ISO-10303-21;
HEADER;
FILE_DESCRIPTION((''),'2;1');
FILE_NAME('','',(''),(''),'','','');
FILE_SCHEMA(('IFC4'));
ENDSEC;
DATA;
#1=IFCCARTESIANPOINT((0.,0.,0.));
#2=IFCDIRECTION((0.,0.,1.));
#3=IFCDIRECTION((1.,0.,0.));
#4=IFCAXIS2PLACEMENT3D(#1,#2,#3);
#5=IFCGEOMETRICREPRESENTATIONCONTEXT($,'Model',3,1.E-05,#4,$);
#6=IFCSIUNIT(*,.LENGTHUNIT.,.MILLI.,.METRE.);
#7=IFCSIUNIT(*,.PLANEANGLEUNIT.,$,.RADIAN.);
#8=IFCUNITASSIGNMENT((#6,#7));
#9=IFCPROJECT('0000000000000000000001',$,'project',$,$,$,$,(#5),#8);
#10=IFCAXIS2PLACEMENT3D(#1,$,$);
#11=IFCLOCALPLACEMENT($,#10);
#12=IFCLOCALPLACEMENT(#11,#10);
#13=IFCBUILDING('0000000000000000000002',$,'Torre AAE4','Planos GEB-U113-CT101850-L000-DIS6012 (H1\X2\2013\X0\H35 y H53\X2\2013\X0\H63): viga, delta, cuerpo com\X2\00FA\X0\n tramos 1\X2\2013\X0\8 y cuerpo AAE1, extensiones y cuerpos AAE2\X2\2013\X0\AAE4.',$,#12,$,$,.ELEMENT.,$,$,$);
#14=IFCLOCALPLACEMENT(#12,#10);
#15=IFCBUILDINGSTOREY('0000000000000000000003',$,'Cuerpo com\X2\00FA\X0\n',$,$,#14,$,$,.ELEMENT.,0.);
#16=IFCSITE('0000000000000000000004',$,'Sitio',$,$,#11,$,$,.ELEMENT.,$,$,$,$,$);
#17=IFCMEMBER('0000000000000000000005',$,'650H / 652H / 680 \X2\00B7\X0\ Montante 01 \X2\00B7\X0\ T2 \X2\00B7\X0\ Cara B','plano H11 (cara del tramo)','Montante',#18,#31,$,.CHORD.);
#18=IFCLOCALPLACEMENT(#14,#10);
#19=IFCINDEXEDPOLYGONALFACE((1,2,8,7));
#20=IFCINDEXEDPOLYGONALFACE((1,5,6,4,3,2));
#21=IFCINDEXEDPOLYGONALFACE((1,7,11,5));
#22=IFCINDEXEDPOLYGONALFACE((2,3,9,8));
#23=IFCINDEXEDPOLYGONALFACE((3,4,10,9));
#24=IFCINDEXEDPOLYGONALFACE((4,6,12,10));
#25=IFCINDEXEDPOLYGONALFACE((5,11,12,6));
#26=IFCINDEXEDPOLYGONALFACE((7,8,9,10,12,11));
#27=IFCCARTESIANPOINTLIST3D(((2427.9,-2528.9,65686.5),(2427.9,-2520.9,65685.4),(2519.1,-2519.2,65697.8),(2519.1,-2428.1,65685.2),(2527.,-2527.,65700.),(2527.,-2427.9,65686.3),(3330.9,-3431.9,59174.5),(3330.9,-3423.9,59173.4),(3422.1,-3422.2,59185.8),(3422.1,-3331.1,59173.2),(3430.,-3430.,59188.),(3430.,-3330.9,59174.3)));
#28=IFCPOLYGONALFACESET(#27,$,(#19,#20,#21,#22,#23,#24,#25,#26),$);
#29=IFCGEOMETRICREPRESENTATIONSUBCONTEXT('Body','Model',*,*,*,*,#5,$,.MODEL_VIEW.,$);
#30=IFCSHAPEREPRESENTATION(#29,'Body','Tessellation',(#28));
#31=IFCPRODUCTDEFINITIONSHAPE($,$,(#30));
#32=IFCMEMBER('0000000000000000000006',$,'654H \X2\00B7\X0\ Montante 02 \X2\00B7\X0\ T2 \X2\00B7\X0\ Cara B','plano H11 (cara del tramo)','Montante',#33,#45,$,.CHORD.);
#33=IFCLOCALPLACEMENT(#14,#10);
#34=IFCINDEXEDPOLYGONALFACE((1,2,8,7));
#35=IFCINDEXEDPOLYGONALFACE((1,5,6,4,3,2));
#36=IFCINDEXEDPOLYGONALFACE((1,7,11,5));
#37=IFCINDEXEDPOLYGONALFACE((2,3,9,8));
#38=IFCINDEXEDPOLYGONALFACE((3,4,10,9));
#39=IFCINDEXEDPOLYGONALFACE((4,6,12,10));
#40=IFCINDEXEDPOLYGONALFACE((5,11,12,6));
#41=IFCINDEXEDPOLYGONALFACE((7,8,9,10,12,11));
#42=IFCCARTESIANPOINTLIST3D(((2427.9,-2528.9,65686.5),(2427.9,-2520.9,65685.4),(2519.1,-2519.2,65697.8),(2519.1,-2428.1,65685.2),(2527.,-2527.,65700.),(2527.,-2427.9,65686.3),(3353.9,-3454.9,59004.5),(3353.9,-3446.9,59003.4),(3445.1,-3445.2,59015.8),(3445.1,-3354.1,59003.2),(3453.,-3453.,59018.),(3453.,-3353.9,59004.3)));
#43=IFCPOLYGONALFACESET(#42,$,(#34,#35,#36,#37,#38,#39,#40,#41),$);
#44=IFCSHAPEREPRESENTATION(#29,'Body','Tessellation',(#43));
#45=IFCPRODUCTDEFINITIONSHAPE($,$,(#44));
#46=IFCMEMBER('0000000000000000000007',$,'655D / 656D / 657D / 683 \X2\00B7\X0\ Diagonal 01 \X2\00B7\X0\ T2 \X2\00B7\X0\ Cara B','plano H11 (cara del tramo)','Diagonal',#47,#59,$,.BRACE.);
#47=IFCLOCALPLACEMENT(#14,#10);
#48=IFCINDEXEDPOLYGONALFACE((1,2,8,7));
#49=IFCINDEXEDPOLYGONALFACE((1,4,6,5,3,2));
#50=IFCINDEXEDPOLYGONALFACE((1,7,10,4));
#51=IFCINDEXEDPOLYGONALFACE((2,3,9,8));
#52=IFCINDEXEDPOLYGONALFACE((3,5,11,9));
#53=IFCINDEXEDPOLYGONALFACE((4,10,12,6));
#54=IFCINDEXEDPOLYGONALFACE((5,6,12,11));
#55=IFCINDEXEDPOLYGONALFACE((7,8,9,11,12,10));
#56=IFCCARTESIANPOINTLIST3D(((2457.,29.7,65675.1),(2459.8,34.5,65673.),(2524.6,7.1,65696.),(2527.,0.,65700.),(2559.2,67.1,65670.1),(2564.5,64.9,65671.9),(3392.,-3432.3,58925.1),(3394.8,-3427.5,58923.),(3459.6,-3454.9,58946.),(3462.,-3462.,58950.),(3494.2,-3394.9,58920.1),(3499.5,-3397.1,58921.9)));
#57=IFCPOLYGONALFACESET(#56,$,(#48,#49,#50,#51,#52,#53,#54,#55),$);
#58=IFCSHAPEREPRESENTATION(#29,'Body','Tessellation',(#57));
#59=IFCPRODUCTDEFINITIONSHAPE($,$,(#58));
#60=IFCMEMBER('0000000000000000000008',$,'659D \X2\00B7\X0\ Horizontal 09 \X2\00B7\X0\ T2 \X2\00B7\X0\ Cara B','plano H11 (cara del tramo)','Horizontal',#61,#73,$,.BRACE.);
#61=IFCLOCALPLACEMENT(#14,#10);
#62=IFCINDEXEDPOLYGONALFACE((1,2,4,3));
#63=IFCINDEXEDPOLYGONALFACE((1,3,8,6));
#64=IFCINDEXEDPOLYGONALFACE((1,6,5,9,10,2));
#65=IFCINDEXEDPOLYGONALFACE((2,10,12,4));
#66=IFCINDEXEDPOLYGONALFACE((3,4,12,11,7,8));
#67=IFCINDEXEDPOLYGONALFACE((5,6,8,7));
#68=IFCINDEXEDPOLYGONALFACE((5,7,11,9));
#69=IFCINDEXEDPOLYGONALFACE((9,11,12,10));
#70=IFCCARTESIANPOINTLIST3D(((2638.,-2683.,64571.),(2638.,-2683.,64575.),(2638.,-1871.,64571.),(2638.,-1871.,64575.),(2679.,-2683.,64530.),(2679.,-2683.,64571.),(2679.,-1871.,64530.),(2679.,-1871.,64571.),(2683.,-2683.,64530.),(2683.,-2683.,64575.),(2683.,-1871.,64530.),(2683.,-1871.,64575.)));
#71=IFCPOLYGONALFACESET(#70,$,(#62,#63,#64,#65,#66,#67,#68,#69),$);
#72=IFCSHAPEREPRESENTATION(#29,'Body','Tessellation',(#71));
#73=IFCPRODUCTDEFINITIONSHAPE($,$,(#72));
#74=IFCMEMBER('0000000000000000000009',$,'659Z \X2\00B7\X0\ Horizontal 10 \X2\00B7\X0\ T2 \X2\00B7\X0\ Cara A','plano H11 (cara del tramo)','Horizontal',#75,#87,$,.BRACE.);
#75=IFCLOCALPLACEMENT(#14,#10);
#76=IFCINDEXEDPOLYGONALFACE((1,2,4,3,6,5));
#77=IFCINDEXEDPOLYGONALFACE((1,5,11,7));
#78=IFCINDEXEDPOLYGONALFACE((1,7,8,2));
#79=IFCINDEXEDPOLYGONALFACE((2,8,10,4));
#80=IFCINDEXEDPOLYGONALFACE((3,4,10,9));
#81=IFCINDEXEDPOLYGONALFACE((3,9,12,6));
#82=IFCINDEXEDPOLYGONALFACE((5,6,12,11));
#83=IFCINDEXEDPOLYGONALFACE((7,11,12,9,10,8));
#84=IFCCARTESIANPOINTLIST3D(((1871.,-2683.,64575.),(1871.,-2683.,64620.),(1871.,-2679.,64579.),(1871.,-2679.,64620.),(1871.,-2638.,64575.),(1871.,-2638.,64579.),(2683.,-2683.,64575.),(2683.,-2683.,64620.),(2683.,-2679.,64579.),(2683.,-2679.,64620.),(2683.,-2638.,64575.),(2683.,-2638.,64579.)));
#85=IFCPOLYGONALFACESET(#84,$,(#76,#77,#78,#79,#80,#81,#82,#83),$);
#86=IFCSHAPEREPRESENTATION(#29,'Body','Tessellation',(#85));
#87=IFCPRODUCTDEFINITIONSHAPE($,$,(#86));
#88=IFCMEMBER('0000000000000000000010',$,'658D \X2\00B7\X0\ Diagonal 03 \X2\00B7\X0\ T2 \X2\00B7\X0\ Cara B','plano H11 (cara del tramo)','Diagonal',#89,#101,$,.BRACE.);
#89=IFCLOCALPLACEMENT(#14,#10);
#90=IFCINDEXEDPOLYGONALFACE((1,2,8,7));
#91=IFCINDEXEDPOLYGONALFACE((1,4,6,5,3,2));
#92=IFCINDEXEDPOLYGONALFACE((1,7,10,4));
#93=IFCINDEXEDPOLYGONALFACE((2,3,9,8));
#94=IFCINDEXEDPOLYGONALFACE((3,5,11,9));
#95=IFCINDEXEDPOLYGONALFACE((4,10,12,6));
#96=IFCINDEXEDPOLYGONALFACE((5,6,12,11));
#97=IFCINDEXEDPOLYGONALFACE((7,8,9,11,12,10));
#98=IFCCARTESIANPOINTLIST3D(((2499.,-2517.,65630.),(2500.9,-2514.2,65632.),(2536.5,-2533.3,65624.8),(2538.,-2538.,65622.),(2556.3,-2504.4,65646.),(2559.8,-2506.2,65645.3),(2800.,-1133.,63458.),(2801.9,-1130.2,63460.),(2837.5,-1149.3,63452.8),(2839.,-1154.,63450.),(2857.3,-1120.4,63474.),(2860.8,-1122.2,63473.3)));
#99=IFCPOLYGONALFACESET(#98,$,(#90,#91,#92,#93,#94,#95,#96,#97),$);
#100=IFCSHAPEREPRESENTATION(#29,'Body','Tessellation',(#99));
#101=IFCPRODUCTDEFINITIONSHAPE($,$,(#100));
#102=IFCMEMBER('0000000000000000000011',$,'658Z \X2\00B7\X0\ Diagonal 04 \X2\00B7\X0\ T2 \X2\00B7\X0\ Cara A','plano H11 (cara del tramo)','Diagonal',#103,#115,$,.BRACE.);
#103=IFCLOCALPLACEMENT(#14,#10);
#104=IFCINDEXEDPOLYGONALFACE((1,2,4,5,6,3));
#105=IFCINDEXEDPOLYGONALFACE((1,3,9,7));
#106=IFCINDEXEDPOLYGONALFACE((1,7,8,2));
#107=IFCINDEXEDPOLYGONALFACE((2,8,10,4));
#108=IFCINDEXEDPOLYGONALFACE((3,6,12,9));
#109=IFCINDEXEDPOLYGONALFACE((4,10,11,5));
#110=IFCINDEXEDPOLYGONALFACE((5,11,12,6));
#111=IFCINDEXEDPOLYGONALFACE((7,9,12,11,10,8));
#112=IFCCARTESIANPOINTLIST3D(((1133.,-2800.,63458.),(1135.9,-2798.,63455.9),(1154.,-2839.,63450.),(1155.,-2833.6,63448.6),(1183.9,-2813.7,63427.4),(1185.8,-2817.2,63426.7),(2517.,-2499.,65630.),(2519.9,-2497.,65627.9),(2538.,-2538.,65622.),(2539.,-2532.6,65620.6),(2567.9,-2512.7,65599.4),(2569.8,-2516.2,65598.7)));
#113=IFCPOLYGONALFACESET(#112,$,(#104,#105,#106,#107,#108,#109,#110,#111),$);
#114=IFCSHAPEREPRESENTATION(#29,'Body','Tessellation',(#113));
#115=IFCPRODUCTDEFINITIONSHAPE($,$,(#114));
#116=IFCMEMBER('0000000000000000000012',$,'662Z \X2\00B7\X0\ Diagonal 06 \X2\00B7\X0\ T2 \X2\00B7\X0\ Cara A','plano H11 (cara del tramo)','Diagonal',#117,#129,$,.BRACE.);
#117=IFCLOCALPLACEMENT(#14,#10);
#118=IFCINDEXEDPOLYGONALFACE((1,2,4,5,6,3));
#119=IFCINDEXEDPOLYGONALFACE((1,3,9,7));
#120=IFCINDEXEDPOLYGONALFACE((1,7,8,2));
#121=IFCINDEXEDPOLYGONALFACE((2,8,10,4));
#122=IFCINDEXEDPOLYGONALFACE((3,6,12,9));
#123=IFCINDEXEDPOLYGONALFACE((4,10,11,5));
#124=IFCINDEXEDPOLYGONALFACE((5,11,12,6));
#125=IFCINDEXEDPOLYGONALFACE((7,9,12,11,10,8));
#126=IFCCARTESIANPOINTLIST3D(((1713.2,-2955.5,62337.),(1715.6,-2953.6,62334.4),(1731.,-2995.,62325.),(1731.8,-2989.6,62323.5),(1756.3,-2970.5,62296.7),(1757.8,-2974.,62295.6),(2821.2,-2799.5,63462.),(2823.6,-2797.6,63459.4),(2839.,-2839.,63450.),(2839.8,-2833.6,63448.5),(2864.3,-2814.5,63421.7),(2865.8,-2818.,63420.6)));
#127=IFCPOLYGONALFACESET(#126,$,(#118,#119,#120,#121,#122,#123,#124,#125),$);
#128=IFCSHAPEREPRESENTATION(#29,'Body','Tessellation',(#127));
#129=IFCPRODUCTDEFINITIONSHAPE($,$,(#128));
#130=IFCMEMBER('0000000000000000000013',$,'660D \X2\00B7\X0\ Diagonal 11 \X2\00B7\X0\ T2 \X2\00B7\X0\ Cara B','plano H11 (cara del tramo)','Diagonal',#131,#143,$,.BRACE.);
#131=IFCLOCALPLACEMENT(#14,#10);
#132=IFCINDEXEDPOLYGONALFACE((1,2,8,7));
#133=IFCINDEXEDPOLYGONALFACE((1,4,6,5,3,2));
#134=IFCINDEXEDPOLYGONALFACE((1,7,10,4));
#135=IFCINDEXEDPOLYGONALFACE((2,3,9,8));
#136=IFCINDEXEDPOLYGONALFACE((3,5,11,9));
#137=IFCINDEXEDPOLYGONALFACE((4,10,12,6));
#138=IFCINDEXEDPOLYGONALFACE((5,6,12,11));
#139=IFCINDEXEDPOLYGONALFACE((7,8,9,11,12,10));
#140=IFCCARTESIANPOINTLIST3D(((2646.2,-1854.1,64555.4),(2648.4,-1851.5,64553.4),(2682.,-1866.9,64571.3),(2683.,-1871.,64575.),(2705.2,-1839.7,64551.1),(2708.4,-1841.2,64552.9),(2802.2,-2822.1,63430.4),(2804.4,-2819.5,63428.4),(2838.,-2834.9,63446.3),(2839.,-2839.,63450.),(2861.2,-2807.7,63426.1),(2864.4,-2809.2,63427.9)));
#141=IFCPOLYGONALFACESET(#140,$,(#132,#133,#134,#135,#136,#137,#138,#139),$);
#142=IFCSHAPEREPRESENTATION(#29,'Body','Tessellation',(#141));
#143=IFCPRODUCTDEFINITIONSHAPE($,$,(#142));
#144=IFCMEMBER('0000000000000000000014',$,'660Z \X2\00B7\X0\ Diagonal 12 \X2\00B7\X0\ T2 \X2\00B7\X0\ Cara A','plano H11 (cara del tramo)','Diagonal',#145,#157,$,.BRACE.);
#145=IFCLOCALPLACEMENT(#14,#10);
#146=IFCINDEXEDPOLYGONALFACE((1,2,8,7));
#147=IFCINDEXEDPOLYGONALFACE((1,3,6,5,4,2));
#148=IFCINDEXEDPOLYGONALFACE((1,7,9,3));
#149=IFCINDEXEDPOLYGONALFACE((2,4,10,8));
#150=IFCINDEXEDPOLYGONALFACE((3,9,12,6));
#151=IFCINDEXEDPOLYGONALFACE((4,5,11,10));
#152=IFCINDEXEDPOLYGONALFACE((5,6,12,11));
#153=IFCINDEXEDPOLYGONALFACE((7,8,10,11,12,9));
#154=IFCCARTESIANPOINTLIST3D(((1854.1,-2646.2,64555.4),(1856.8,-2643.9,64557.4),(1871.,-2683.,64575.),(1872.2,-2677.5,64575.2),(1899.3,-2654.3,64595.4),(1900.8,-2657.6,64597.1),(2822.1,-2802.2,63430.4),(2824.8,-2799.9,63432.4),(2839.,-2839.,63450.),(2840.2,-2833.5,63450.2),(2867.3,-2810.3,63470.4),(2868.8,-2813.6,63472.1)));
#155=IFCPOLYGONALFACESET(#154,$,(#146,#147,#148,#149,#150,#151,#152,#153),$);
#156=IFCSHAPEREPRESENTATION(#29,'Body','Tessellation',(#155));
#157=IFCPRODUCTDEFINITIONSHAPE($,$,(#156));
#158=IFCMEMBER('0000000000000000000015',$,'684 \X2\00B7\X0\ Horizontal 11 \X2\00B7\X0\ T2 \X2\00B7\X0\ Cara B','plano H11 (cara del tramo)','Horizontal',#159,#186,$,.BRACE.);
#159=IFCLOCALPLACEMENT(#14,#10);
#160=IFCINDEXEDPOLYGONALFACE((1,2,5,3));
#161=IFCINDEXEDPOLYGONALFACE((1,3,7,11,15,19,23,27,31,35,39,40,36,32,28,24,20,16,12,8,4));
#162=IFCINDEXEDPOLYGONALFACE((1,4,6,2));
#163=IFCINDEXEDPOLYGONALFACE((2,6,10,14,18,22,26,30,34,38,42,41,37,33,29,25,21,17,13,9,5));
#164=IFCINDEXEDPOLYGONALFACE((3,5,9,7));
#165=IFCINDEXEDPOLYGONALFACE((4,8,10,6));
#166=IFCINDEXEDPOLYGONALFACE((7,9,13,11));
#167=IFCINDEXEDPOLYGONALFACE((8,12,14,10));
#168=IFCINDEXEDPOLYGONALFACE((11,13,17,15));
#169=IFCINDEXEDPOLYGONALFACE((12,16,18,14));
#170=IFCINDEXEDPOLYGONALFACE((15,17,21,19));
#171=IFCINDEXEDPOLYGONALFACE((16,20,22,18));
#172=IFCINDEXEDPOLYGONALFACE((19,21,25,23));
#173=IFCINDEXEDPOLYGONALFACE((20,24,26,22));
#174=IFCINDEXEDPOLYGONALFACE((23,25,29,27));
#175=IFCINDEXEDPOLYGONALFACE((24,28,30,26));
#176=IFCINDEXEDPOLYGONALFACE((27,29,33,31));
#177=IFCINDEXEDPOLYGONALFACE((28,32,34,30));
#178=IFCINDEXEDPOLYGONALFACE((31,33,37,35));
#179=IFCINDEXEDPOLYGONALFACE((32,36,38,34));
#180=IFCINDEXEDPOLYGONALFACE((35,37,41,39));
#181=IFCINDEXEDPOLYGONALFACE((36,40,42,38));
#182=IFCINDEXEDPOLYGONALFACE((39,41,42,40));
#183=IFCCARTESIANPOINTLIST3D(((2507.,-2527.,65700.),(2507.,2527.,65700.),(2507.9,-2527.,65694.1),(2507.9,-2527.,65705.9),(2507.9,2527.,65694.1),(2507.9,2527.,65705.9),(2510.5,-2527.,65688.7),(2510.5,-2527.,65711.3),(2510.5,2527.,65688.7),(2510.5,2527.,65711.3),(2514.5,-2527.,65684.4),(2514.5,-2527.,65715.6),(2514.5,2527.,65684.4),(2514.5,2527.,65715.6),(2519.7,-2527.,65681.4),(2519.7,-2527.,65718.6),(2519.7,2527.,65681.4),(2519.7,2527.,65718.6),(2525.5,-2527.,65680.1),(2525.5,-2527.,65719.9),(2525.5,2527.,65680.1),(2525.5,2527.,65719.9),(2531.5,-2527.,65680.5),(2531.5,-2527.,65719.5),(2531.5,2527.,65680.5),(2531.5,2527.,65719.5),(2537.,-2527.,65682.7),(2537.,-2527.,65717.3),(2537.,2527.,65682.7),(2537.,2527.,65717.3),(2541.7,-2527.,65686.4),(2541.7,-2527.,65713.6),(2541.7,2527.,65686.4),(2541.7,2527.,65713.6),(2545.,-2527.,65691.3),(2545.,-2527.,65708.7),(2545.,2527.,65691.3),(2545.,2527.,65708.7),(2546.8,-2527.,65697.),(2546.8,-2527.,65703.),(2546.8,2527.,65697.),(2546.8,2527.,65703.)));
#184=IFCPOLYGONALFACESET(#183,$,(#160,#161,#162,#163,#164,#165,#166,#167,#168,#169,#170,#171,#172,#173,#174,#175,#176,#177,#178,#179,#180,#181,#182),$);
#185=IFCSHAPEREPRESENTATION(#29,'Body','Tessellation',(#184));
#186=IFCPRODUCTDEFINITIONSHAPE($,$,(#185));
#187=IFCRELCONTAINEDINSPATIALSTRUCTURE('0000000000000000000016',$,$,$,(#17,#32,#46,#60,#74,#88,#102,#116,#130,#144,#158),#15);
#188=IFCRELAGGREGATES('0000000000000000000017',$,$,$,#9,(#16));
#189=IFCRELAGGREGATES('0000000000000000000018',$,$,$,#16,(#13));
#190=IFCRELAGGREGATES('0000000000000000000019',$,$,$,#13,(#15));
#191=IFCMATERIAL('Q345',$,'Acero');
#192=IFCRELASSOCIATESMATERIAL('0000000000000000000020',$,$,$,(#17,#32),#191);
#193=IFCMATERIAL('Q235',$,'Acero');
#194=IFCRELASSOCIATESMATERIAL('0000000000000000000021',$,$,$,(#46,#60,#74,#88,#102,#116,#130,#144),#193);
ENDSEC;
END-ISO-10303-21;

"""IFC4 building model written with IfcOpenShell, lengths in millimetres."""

from ifc_helpers import new_model, si_unit, frame, frame_2d, origin, origin_with_axes, place, context, subcontext, project, spatial, circle, l_section, extrude, material, element, save


model = new_model("IFC4")

# Units and contexts
model_context = context("Model", 3, precision=1e-05, world=origin_with_axes())
body_context = subcontext(model_context, "Body", "Model", "MODEL_VIEW")
ifc_project = project(units=[si_unit("LENGTHUNIT", "METRE", prefix="MILLI"), si_unit("PLANEANGLEUNIT", "RADIAN")], contexts=[model_context])

# Site, building, storey
site_placement = place(None, origin())
site = spatial("IfcSite", under=ifc_project, at=site_placement, Name="Sitio", CompositionType="ELEMENT")
building_placement = place(site_placement, origin())
building = spatial("IfcBuilding", under=site, at=building_placement, Name="Torre AAE4", Description="Planos GEB-U113-CT101850-L000-DIS6012 (H1–H35 y H53–H63): viga, delta, cuerpo común tramos 1–8 y cuerpo AAE1, extensiones y cuerpos AAE2–AAE4.", CompositionType="ELEMENT")
storey_placement = place(building_placement, origin())
storey = spatial("IfcBuildingStorey", under=building, at=storey_placement, Name="Cuerpo común", CompositionType="ELEMENT", Elevation=0.0)

# Members
ifc_material_1 = material(Name="Q235", Category="Acero")
ifc_material_2 = material(Name="Q345", Category="Acero")
member_1_placement = place(storey_placement, frame((2527.0, -2527.0, 65700.0), z_axis=(0.136075, -0.136075, -0.981309), x_axis=(-0.990699, -0.01869, -0.134786)))
element("IfcMember", 1, at=member_1_placement, inside=storey, material=ifc_material_2, Name="650H / 652H / 680 · Montante 01 · T2 · Cara B", Description="plano H11 (cara del tramo)", ObjectType="Montante", PredefinedType="CHORD", context=body_context, shape_type="SweptSolid", body=[
    extrude(l_section(Depth=100.0, Width=100.0, Thickness=8.0, at=frame_2d((50.0, 50.0))), None, (0.0, 0.0, 1.0), 6636.0),
])
member_2_placement = place(storey_placement, frame((2527.0, -2527.0, 65700.0), z_axis=(0.135994, -0.135994, -0.981331), x_axis=(-0.99071, -0.018668, -0.134707)))
element("IfcMember", 2, at=member_2_placement, inside=storey, material=ifc_material_2, Name="654H · Montante 02 · T2 · Cara B", Description="plano H11 (cara del tramo)", ObjectType="Montante", PredefinedType="CHORD", context=body_context, shape_type="SweptSolid", body=[
    extrude(l_section(Depth=100.0, Width=100.0, Thickness=8.0, at=frame_2d((50.0, 50.0))), None, (0.0, 0.0, 1.0), 6809.1),
])
member_3_placement = place(storey_placement, frame((2527.0, 0.0, 65700.0), z_axis=(0.122327, -0.452937, -0.88311), x_axis=(-0.874879, 0.370937, -0.311437)))
element("IfcMember", 3, at=member_3_placement, inside=storey, material=ifc_material_1, Name="655D / 656D / 657D / 683 · Diagonal 01 · T2 · Cara B", Description="plano H11 (cara del tramo)", ObjectType="Diagonal", PredefinedType="BRACE", context=body_context, shape_type="SweptSolid", body=[
    extrude(l_section(Depth=80.0, Width=80.0, Thickness=6.0, at=frame_2d((40.0, 40.0))), None, (0.0, 0.0, 1.0), 7643.4),
])
for number, where, z_axis, x_axis, name in (
    (4, (2683.0, -1871.0, 64575.0), (0.0, -1.0, 0.0), (-1.0, 0.0, 0.0), "659D · Horizontal 09 · T2 · Cara B"),
    (5, (1871.0, -2683.0, 64575.0), (1.0, 0.0, 0.0), (0.0, 1.0, 0.0), "659Z · Horizontal 10 · T2 · Cara A"),
):
    element("IfcMember", number, at=place(storey_placement, frame(where, z_axis=z_axis, x_axis=x_axis)), inside=storey, material=ifc_material_1, Name=name, Description="plano H11 (cara del tramo)", ObjectType="Horizontal", PredefinedType="BRACE", context=body_context, shape_type="SweptSolid", body=[
        extrude(l_section(Depth=45.0, Width=45.0, Thickness=4.0, at=frame_2d((22.5, 22.5))), None, (0.0, 0.0, 1.0), 812.0),
    ])
for number, where, z_axis, x_axis, name in (
    (6, (2538.0, -2538.0, 65622.0), (0.116082, 0.533745, -0.83764), (-0.867013, 0.465896, 0.176717), "658D · Diagonal 03 · T2 · Cara B"),
    (7, (2538.0, -2538.0, 65622.0), (-0.533745, -0.116082, -0.83764), (-0.465896, 0.867013, 0.176717), "658Z · Diagonal 04 · T2 · Cara A"),
):
    element("IfcMember", number, at=place(storey_placement, frame(where, z_axis=z_axis, x_axis=x_axis)), inside=storey, material=ifc_material_1, Name=name, Description="plano H11 (cara del tramo)", ObjectType="Diagonal", PredefinedType="BRACE", context=body_context, shape_type="SweptSolid", body=[
        extrude(l_section(Depth=45.0, Width=45.0, Thickness=4.0, at=frame_2d((22.5, 22.5))), None, (0.0, 0.0, 1.0), 2593.0),
    ])
member_4_placement = place(storey_placement, frame((2839.0, -2839.0, 63450.0), z_axis=(-0.698304, -0.098317, -0.709018), x_axis=(-0.395503, 0.878588, 0.267696)))
element("IfcMember", 8, at=member_4_placement, inside=storey, material=ifc_material_1, Name="662Z · Diagonal 06 · T2 · Cara A", Description="plano H11 (cara del tramo)", ObjectType="Diagonal", PredefinedType="BRACE", context=body_context, shape_type="SweptSolid", body=[
    extrude(l_section(Depth=45.0, Width=45.0, Thickness=4.0, at=frame_2d((22.5, 22.5))), None, (0.0, 0.0, 1.0), 1586.7),
])
for number, where, z_axis, x_axis, name in (
    (9, (2683.0, -1871.0, 64575.0), (0.104536, -0.648659, -0.753866), (-0.818382, 0.3746, -0.435805), "660D · Diagonal 11 · T2 · Cara B"),
    (10, (1871.0, -2683.0, 64575.0), (0.648659, -0.104536, -0.753866), (-0.3746, 0.818382, -0.435805), "660Z · Diagonal 12 · T2 · Cara A"),
):
    element("IfcMember", number, at=place(storey_placement, frame(where, z_axis=z_axis, x_axis=x_axis)), inside=storey, material=ifc_material_1, Name=name, Description="plano H11 (cara del tramo)", ObjectType="Diagonal", PredefinedType="BRACE", context=body_context, shape_type="SweptSolid", body=[
        extrude(l_section(Depth=45.0, Width=45.0, Thickness=4.0, at=frame_2d((22.5, 22.5))), None, (0.0, 0.0, 1.0), 1492.3),
    ])
member_5_placement = place(storey_placement, frame((2527.0, -2527.0, 65700.0), z_axis=(0.0, 1.0, 0.0), x_axis=(-1.0, 0.0, 0.0)))
element("IfcMember", 11, at=member_5_placement, inside=storey, Name="684 · Horizontal 11 · T2 · Cara B", Description="plano H11 (cara del tramo)", ObjectType="Horizontal", PredefinedType="BRACE", context=body_context, shape_type="SweptSolid", body=[
    extrude(circle(Radius=20.0), None, (0.0, 0.0, 1.0), 5054.0),
])

save(model, "model.ifc")
